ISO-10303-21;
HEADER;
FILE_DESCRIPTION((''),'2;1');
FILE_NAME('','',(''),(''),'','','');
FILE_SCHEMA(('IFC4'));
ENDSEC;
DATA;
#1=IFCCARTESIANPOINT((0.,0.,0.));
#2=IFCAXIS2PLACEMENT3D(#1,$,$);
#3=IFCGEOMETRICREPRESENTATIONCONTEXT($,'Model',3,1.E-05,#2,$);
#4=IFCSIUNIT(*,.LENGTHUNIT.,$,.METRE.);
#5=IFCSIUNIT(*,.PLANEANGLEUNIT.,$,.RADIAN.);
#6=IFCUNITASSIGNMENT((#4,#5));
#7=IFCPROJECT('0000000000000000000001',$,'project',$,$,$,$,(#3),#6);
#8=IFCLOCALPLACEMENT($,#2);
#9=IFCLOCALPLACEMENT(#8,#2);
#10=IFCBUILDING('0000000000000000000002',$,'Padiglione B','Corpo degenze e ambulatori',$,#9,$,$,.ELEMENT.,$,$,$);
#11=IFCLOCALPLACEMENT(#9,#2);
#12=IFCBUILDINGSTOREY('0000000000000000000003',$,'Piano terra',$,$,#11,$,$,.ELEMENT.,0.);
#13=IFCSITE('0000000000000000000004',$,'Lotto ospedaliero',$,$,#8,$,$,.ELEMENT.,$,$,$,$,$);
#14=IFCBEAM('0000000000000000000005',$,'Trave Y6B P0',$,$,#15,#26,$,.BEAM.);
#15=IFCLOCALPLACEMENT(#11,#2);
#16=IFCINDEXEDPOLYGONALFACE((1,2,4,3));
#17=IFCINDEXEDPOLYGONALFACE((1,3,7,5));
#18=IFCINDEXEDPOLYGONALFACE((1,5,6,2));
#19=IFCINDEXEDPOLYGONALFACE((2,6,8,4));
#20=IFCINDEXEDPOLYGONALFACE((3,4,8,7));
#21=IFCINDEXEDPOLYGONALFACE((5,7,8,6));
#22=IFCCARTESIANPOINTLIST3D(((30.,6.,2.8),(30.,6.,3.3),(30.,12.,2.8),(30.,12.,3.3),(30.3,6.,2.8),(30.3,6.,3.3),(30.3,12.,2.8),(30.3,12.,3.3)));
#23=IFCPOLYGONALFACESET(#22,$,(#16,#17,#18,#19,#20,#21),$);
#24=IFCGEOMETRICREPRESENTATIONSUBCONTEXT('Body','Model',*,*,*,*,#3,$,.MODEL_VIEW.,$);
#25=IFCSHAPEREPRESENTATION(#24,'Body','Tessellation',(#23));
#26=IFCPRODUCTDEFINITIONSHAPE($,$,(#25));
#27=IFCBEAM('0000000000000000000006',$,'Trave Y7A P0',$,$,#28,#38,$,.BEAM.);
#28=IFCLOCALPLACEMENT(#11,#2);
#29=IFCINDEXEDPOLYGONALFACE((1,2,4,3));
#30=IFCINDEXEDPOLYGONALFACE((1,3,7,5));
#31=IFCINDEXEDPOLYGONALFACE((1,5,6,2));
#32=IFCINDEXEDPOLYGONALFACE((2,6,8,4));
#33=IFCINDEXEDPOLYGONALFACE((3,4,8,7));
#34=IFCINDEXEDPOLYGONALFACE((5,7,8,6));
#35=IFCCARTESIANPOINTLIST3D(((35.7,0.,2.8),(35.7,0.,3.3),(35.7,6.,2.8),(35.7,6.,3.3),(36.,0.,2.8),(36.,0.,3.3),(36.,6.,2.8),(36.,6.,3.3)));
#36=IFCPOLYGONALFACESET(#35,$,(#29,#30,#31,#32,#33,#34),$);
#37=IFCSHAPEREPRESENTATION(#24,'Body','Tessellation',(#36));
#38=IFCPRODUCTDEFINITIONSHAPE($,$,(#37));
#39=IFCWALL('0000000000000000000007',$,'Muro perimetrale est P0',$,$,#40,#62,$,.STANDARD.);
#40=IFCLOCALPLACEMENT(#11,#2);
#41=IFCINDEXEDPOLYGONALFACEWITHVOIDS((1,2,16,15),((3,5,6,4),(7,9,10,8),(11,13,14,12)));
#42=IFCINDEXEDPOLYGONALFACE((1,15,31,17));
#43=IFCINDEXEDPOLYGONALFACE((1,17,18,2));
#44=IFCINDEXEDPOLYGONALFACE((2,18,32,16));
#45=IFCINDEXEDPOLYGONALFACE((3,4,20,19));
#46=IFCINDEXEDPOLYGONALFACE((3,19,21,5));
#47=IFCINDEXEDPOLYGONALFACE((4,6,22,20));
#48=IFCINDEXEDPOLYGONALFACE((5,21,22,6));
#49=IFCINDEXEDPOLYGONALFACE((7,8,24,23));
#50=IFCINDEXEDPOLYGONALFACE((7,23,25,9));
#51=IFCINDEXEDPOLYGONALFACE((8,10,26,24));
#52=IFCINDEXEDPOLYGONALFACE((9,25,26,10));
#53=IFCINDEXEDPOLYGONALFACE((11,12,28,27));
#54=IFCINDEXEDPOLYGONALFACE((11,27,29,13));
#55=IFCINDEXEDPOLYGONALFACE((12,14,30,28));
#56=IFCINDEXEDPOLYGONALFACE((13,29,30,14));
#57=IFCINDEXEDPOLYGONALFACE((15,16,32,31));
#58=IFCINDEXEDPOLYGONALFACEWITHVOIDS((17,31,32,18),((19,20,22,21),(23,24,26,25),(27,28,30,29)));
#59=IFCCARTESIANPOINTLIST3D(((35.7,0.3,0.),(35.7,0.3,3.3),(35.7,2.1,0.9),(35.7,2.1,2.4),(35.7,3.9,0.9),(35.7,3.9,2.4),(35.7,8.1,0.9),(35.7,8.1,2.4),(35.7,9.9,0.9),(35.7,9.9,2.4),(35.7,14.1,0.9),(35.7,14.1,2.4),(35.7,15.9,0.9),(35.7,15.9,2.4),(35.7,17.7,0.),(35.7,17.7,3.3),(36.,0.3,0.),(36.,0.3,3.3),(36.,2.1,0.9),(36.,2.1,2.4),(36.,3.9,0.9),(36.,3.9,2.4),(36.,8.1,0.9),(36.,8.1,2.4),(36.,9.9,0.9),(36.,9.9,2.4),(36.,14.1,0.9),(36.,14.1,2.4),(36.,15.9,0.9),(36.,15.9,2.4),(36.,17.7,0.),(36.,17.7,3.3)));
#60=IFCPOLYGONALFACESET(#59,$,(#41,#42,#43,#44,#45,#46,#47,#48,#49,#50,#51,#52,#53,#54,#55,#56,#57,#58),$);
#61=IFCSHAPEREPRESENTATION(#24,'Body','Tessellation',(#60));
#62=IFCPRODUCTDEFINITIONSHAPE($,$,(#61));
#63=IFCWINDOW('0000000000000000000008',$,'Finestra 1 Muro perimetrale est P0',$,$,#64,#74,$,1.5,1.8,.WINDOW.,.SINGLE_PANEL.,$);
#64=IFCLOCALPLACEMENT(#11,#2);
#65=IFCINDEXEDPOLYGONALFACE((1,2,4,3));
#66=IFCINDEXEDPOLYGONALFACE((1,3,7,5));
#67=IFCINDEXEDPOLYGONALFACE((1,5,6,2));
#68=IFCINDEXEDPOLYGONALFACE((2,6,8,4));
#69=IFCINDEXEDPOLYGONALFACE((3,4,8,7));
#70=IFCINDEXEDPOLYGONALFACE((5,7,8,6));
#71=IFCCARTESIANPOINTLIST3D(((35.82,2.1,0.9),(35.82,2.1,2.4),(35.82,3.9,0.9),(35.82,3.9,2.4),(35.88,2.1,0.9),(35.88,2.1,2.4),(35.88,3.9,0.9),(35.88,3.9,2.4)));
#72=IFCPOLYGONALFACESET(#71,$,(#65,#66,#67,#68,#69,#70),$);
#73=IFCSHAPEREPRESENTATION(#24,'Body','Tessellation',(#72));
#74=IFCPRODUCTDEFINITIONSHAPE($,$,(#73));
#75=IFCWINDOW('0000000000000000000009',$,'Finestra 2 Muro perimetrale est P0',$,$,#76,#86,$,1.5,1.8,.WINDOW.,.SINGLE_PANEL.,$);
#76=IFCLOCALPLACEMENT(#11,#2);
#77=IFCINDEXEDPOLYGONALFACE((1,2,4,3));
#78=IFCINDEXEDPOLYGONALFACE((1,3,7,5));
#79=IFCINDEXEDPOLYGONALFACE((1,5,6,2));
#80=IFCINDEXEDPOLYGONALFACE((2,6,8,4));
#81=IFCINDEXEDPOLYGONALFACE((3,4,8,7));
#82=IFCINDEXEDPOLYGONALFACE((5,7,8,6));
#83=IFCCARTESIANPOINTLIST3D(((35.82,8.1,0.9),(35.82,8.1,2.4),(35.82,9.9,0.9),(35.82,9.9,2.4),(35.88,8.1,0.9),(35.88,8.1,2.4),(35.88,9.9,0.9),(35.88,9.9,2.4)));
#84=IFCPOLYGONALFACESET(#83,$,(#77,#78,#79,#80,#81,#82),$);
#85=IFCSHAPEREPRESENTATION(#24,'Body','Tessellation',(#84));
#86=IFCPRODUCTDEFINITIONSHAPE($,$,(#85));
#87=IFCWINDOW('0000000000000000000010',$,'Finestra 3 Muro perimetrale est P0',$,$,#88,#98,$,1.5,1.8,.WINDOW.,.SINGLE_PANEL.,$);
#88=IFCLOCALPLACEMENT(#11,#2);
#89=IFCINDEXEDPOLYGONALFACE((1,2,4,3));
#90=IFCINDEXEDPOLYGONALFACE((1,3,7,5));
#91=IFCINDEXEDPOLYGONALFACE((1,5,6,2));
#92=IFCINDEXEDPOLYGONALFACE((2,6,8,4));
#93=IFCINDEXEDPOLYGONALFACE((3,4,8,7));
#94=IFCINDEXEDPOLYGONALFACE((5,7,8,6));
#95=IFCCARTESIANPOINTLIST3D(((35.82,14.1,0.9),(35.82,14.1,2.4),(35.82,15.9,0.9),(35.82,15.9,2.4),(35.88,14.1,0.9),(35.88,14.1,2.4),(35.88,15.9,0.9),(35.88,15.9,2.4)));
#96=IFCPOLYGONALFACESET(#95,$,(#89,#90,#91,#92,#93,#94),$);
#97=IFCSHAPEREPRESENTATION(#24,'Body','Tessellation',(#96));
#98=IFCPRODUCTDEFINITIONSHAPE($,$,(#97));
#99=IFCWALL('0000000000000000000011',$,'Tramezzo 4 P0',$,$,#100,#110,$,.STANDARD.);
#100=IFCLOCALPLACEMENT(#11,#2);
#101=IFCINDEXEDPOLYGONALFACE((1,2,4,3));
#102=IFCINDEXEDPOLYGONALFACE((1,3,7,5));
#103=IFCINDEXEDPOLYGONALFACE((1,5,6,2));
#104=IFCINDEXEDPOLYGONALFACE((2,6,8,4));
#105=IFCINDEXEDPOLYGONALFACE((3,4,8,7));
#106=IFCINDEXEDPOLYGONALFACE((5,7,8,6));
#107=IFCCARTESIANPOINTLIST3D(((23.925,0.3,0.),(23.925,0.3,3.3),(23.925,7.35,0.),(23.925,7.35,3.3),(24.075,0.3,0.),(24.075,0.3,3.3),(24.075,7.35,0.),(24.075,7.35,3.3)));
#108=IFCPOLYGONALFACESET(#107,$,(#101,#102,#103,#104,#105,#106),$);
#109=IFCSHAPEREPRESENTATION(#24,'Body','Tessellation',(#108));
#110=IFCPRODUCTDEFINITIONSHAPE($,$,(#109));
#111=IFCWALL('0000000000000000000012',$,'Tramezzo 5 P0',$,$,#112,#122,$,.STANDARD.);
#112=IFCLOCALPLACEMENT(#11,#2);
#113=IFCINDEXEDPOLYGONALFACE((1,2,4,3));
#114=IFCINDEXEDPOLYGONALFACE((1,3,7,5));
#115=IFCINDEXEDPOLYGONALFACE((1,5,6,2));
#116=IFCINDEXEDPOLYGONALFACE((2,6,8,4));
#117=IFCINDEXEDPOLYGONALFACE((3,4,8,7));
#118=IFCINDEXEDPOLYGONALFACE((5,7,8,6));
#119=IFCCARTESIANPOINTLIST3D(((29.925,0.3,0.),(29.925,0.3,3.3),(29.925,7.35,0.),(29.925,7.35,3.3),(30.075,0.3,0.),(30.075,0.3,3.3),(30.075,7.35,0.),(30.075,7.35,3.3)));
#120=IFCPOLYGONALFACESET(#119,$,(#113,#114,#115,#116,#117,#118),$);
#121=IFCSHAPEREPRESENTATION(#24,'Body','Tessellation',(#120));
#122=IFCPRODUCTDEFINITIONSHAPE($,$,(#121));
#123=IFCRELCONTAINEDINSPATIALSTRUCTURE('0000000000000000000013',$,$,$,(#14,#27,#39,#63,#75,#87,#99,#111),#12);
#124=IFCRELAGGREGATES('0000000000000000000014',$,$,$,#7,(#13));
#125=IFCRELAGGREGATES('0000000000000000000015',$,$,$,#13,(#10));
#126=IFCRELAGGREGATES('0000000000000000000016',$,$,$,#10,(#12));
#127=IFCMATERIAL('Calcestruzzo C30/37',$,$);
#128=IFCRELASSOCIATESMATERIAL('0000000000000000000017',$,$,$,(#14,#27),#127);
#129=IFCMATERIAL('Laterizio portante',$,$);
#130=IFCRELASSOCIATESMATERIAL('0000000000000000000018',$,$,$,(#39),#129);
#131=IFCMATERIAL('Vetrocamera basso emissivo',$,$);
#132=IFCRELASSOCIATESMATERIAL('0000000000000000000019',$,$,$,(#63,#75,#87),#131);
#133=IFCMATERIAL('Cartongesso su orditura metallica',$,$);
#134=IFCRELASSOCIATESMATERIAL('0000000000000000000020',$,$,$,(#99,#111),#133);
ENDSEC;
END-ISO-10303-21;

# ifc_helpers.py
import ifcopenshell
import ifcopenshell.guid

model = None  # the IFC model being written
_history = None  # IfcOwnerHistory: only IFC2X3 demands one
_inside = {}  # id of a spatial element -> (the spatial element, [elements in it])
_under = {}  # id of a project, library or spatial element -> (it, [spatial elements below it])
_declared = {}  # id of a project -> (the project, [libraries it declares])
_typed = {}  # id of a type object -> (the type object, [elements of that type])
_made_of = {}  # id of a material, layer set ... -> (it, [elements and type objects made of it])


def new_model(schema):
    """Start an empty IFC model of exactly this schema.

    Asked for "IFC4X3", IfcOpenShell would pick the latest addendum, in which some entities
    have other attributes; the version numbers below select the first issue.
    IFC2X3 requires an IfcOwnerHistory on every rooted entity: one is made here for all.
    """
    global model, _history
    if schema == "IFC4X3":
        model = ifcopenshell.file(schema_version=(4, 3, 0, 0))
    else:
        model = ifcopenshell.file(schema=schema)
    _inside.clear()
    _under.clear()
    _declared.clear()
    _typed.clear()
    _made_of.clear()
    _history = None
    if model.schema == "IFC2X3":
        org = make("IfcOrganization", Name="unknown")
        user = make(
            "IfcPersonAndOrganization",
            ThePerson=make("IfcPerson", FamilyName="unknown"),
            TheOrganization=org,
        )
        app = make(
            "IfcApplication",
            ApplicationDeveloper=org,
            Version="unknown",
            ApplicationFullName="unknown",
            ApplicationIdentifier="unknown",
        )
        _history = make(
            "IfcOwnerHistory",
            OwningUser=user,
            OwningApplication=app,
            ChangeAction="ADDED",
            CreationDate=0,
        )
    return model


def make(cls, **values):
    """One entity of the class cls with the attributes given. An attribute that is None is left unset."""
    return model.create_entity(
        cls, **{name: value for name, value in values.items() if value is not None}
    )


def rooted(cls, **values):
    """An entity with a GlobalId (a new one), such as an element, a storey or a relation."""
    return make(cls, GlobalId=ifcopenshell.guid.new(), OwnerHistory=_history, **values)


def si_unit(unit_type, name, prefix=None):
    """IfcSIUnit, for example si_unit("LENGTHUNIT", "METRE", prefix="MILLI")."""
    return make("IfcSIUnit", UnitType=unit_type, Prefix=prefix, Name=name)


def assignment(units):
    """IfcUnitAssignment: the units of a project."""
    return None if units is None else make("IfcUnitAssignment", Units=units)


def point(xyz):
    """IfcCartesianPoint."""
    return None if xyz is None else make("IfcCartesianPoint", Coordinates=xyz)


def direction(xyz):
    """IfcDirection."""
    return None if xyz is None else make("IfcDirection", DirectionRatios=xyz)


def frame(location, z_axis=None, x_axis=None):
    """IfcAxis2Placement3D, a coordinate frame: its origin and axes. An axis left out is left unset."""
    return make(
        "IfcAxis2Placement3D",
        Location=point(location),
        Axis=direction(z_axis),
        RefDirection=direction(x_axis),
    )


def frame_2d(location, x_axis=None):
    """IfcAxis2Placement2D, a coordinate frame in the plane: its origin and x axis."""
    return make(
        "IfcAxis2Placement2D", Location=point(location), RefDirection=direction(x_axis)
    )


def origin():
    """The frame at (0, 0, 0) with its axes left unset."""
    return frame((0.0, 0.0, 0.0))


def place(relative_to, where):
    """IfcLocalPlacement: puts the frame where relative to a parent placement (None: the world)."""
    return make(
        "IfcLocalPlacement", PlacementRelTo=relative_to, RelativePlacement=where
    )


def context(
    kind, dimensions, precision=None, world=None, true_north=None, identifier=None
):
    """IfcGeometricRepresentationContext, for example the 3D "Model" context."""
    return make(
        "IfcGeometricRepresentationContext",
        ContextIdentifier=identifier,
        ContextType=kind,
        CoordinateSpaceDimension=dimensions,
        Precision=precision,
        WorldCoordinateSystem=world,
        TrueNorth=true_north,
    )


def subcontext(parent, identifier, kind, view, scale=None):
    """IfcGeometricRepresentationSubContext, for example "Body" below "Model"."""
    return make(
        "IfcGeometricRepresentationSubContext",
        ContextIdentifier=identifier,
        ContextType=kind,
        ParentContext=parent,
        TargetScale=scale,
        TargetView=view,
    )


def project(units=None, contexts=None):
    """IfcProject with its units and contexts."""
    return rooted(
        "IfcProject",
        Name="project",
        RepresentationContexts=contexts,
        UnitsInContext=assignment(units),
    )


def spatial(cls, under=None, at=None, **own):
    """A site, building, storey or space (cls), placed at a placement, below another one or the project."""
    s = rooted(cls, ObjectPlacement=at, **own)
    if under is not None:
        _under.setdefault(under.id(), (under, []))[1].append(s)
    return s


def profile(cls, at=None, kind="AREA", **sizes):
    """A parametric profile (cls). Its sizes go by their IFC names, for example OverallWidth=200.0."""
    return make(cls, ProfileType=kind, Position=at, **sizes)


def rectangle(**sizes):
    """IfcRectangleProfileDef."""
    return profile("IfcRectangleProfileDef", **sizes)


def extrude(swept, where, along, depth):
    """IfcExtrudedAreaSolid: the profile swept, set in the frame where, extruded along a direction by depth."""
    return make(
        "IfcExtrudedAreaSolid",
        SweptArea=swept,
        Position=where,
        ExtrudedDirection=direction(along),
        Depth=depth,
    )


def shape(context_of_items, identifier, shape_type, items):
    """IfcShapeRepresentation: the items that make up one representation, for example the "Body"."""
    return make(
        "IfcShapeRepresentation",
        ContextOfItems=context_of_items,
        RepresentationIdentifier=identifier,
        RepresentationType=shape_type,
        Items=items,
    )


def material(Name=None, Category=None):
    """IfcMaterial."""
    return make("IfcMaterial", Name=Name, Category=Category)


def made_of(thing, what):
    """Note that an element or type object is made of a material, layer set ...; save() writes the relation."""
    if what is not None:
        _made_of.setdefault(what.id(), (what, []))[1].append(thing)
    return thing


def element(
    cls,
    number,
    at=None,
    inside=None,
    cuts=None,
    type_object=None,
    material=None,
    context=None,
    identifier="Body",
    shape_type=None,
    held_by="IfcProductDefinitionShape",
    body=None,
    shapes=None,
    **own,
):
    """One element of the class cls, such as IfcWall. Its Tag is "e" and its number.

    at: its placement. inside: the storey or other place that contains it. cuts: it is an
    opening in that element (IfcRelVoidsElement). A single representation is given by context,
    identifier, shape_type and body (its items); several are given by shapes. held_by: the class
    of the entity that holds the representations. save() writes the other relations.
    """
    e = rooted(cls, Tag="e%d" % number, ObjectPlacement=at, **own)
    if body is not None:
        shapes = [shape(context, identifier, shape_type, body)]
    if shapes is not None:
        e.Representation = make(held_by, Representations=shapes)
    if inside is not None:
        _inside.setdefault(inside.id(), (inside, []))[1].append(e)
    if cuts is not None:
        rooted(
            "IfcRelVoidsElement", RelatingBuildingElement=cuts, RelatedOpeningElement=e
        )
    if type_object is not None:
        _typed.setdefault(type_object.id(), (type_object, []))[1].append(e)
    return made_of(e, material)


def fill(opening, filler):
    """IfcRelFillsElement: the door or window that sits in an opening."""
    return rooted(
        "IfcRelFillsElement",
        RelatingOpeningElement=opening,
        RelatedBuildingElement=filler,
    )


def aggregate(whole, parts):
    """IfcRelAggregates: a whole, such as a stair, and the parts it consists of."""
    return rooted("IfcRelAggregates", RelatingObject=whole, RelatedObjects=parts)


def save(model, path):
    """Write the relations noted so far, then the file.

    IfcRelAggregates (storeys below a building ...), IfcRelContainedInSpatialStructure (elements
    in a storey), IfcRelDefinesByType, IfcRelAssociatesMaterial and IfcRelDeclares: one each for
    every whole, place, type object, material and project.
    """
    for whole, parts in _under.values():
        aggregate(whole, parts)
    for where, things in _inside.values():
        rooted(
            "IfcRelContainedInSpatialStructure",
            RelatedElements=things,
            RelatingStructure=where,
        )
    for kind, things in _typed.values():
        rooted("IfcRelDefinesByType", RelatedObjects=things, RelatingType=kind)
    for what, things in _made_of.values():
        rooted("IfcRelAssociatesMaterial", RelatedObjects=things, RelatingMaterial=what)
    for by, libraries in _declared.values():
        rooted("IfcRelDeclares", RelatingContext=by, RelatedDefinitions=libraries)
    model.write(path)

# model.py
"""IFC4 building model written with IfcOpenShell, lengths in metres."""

from ifc_helpers import new_model, si_unit, frame, frame_2d, origin, place, context, subcontext, project, spatial, rectangle, extrude, material, element, fill, save


model = new_model("IFC4")

# Units and contexts
model_context = context("Model", 3, precision=1e-05, world=origin())
body_context = subcontext(model_context, "Body", "Model", "MODEL_VIEW")
ifc_project = project(units=[si_unit("LENGTHUNIT", "METRE"), si_unit("PLANEANGLEUNIT", "RADIAN")], contexts=[model_context])

# Site, building, storey
site_placement = place(None, origin())
site = spatial("IfcSite", under=ifc_project, at=site_placement, Name="Lotto ospedaliero", CompositionType="ELEMENT")
building_placement = place(site_placement, origin())
building = spatial("IfcBuilding", under=site, at=building_placement, Name="Padiglione B", Description="Corpo degenze e ambulatori", CompositionType="ELEMENT")
storey_placement = place(building_placement, origin())
storey = spatial("IfcBuildingStorey", under=building, at=storey_placement, Name="Piano terra", CompositionType="ELEMENT", Elevation=0.0)

# Shared definitions
ifc_material_1 = material(Name="Calcestruzzo C30/37")

# Beams
for number, where, name in (
    (1, (30.0, 6.0, 2.8), "Trave Y6B P0"),
    (2, (35.7, 0.0, 2.8), "Trave Y7A P0"),
):
    element("IfcBeam", number, at=place(storey_placement, frame(where)), inside=storey, material=ifc_material_1, Name=name, PredefinedType="BEAM", context=body_context, shape_type="SweptSolid", body=[
        extrude(rectangle(XDim=0.3, YDim=6.0, at=frame_2d((0.15, 3.0))), origin(), (0.0, 0.0, 1.0), 0.5),
    ])

# Wall, openings, windows
ifc_material_2 = material(Name="Laterizio portante")
wall_placement = place(storey_placement, frame((35.7, 0.3, 0.0)))
wall = element("IfcWall", 3, at=wall_placement, inside=storey, material=ifc_material_2, Name="Muro perimetrale est P0", PredefinedType="STANDARD", context=body_context, shape_type="SweptSolid", body=[
    extrude(rectangle(XDim=0.3, YDim=17.4, at=frame_2d((0.15, 8.7))), origin(), (0.0, 0.0, 1.0), 3.3),
])
opening_1_placement = place(wall_placement, frame((-0.1, 1.8, 0.9)))
opening_1 = element("IfcOpeningElement", 4, at=opening_1_placement, cuts=wall, PredefinedType="OPENING", context=body_context, shape_type="SweptSolid", body=[
    extrude(rectangle(XDim=0.5, YDim=1.8, at=frame_2d((0.25, 0.9))), origin(), (0.0, 0.0, 1.0), 1.5),
])
opening_2_placement = place(wall_placement, frame((-0.1, 7.8, 0.9)))
opening_2 = element("IfcOpeningElement", 5, at=opening_2_placement, cuts=wall, PredefinedType="OPENING", context=body_context, shape_type="SweptSolid", body=[
    extrude(rectangle(XDim=0.5, YDim=1.8, at=frame_2d((0.25, 0.9))), origin(), (0.0, 0.0, 1.0), 1.5),
])
opening_3_placement = place(wall_placement, frame((-0.1, 13.8, 0.9)))
opening_3 = element("IfcOpeningElement", 6, at=opening_3_placement, cuts=wall, PredefinedType="OPENING", context=body_context, shape_type="SweptSolid", body=[
    extrude(rectangle(XDim=0.5, YDim=1.8, at=frame_2d((0.25, 0.9))), origin(), (0.0, 0.0, 1.0), 1.5),
])
ifc_material_3 = material(Name="Vetrocamera basso emissivo")
window_1_placement = place(wall_placement, frame((0.12, 1.8, 0.9)))
window_1 = element("IfcWindow", 7, at=window_1_placement, inside=storey, material=ifc_material_3, Name="Finestra 1 Muro perimetrale est P0", OverallHeight=1.5, OverallWidth=1.8, PartitioningType="SINGLE_PANEL", PredefinedType="WINDOW", context=body_context, shape_type="SweptSolid", body=[
    extrude(rectangle(XDim=0.06, YDim=1.8, at=frame_2d((0.03, 0.9))), origin(), (0.0, 0.0, 1.0), 1.5),
])
fill(opening_1, window_1)
window_2_placement = place(wall_placement, frame((0.12, 7.8, 0.9)))
window_2 = element("IfcWindow", 8, at=window_2_placement, inside=storey, material=ifc_material_3, Name="Finestra 2 Muro perimetrale est P0", OverallHeight=1.5, OverallWidth=1.8, PartitioningType="SINGLE_PANEL", PredefinedType="WINDOW", context=body_context, shape_type="SweptSolid", body=[
    extrude(rectangle(XDim=0.06, YDim=1.8, at=frame_2d((0.03, 0.9))), origin(), (0.0, 0.0, 1.0), 1.5),
])
fill(opening_2, window_2)
window_3_placement = place(wall_placement, frame((0.12, 13.8, 0.9)))
window_3 = element("IfcWindow", 9, at=window_3_placement, inside=storey, material=ifc_material_3, Name="Finestra 3 Muro perimetrale est P0", OverallHeight=1.5, OverallWidth=1.8, PartitioningType="SINGLE_PANEL", PredefinedType="WINDOW", context=body_context, shape_type="SweptSolid", body=[
    extrude(rectangle(XDim=0.06, YDim=1.8, at=frame_2d((0.03, 0.9))), origin(), (0.0, 0.0, 1.0), 1.5),
])
fill(opening_3, window_3)

# Walls
ifc_material_4 = material(Name="Cartongesso su orditura metallica")
for number, where, name in (
    (10, (23.925, 0.3, 0.0), "Tramezzo 4 P0"),
    (11, (29.925, 0.3, 0.0), "Tramezzo 5 P0"),
):
    element("IfcWall", number, at=place(storey_placement, frame(where)), inside=storey, material=ifc_material_4, Name=name, PredefinedType="STANDARD", context=body_context, shape_type="SweptSolid", body=[
        extrude(rectangle(XDim=0.15, YDim=7.05, at=frame_2d((0.075, 3.525))), origin(), (0.0, 0.0, 1.0), 3.3),
    ])

save(model, "model.ifc")
